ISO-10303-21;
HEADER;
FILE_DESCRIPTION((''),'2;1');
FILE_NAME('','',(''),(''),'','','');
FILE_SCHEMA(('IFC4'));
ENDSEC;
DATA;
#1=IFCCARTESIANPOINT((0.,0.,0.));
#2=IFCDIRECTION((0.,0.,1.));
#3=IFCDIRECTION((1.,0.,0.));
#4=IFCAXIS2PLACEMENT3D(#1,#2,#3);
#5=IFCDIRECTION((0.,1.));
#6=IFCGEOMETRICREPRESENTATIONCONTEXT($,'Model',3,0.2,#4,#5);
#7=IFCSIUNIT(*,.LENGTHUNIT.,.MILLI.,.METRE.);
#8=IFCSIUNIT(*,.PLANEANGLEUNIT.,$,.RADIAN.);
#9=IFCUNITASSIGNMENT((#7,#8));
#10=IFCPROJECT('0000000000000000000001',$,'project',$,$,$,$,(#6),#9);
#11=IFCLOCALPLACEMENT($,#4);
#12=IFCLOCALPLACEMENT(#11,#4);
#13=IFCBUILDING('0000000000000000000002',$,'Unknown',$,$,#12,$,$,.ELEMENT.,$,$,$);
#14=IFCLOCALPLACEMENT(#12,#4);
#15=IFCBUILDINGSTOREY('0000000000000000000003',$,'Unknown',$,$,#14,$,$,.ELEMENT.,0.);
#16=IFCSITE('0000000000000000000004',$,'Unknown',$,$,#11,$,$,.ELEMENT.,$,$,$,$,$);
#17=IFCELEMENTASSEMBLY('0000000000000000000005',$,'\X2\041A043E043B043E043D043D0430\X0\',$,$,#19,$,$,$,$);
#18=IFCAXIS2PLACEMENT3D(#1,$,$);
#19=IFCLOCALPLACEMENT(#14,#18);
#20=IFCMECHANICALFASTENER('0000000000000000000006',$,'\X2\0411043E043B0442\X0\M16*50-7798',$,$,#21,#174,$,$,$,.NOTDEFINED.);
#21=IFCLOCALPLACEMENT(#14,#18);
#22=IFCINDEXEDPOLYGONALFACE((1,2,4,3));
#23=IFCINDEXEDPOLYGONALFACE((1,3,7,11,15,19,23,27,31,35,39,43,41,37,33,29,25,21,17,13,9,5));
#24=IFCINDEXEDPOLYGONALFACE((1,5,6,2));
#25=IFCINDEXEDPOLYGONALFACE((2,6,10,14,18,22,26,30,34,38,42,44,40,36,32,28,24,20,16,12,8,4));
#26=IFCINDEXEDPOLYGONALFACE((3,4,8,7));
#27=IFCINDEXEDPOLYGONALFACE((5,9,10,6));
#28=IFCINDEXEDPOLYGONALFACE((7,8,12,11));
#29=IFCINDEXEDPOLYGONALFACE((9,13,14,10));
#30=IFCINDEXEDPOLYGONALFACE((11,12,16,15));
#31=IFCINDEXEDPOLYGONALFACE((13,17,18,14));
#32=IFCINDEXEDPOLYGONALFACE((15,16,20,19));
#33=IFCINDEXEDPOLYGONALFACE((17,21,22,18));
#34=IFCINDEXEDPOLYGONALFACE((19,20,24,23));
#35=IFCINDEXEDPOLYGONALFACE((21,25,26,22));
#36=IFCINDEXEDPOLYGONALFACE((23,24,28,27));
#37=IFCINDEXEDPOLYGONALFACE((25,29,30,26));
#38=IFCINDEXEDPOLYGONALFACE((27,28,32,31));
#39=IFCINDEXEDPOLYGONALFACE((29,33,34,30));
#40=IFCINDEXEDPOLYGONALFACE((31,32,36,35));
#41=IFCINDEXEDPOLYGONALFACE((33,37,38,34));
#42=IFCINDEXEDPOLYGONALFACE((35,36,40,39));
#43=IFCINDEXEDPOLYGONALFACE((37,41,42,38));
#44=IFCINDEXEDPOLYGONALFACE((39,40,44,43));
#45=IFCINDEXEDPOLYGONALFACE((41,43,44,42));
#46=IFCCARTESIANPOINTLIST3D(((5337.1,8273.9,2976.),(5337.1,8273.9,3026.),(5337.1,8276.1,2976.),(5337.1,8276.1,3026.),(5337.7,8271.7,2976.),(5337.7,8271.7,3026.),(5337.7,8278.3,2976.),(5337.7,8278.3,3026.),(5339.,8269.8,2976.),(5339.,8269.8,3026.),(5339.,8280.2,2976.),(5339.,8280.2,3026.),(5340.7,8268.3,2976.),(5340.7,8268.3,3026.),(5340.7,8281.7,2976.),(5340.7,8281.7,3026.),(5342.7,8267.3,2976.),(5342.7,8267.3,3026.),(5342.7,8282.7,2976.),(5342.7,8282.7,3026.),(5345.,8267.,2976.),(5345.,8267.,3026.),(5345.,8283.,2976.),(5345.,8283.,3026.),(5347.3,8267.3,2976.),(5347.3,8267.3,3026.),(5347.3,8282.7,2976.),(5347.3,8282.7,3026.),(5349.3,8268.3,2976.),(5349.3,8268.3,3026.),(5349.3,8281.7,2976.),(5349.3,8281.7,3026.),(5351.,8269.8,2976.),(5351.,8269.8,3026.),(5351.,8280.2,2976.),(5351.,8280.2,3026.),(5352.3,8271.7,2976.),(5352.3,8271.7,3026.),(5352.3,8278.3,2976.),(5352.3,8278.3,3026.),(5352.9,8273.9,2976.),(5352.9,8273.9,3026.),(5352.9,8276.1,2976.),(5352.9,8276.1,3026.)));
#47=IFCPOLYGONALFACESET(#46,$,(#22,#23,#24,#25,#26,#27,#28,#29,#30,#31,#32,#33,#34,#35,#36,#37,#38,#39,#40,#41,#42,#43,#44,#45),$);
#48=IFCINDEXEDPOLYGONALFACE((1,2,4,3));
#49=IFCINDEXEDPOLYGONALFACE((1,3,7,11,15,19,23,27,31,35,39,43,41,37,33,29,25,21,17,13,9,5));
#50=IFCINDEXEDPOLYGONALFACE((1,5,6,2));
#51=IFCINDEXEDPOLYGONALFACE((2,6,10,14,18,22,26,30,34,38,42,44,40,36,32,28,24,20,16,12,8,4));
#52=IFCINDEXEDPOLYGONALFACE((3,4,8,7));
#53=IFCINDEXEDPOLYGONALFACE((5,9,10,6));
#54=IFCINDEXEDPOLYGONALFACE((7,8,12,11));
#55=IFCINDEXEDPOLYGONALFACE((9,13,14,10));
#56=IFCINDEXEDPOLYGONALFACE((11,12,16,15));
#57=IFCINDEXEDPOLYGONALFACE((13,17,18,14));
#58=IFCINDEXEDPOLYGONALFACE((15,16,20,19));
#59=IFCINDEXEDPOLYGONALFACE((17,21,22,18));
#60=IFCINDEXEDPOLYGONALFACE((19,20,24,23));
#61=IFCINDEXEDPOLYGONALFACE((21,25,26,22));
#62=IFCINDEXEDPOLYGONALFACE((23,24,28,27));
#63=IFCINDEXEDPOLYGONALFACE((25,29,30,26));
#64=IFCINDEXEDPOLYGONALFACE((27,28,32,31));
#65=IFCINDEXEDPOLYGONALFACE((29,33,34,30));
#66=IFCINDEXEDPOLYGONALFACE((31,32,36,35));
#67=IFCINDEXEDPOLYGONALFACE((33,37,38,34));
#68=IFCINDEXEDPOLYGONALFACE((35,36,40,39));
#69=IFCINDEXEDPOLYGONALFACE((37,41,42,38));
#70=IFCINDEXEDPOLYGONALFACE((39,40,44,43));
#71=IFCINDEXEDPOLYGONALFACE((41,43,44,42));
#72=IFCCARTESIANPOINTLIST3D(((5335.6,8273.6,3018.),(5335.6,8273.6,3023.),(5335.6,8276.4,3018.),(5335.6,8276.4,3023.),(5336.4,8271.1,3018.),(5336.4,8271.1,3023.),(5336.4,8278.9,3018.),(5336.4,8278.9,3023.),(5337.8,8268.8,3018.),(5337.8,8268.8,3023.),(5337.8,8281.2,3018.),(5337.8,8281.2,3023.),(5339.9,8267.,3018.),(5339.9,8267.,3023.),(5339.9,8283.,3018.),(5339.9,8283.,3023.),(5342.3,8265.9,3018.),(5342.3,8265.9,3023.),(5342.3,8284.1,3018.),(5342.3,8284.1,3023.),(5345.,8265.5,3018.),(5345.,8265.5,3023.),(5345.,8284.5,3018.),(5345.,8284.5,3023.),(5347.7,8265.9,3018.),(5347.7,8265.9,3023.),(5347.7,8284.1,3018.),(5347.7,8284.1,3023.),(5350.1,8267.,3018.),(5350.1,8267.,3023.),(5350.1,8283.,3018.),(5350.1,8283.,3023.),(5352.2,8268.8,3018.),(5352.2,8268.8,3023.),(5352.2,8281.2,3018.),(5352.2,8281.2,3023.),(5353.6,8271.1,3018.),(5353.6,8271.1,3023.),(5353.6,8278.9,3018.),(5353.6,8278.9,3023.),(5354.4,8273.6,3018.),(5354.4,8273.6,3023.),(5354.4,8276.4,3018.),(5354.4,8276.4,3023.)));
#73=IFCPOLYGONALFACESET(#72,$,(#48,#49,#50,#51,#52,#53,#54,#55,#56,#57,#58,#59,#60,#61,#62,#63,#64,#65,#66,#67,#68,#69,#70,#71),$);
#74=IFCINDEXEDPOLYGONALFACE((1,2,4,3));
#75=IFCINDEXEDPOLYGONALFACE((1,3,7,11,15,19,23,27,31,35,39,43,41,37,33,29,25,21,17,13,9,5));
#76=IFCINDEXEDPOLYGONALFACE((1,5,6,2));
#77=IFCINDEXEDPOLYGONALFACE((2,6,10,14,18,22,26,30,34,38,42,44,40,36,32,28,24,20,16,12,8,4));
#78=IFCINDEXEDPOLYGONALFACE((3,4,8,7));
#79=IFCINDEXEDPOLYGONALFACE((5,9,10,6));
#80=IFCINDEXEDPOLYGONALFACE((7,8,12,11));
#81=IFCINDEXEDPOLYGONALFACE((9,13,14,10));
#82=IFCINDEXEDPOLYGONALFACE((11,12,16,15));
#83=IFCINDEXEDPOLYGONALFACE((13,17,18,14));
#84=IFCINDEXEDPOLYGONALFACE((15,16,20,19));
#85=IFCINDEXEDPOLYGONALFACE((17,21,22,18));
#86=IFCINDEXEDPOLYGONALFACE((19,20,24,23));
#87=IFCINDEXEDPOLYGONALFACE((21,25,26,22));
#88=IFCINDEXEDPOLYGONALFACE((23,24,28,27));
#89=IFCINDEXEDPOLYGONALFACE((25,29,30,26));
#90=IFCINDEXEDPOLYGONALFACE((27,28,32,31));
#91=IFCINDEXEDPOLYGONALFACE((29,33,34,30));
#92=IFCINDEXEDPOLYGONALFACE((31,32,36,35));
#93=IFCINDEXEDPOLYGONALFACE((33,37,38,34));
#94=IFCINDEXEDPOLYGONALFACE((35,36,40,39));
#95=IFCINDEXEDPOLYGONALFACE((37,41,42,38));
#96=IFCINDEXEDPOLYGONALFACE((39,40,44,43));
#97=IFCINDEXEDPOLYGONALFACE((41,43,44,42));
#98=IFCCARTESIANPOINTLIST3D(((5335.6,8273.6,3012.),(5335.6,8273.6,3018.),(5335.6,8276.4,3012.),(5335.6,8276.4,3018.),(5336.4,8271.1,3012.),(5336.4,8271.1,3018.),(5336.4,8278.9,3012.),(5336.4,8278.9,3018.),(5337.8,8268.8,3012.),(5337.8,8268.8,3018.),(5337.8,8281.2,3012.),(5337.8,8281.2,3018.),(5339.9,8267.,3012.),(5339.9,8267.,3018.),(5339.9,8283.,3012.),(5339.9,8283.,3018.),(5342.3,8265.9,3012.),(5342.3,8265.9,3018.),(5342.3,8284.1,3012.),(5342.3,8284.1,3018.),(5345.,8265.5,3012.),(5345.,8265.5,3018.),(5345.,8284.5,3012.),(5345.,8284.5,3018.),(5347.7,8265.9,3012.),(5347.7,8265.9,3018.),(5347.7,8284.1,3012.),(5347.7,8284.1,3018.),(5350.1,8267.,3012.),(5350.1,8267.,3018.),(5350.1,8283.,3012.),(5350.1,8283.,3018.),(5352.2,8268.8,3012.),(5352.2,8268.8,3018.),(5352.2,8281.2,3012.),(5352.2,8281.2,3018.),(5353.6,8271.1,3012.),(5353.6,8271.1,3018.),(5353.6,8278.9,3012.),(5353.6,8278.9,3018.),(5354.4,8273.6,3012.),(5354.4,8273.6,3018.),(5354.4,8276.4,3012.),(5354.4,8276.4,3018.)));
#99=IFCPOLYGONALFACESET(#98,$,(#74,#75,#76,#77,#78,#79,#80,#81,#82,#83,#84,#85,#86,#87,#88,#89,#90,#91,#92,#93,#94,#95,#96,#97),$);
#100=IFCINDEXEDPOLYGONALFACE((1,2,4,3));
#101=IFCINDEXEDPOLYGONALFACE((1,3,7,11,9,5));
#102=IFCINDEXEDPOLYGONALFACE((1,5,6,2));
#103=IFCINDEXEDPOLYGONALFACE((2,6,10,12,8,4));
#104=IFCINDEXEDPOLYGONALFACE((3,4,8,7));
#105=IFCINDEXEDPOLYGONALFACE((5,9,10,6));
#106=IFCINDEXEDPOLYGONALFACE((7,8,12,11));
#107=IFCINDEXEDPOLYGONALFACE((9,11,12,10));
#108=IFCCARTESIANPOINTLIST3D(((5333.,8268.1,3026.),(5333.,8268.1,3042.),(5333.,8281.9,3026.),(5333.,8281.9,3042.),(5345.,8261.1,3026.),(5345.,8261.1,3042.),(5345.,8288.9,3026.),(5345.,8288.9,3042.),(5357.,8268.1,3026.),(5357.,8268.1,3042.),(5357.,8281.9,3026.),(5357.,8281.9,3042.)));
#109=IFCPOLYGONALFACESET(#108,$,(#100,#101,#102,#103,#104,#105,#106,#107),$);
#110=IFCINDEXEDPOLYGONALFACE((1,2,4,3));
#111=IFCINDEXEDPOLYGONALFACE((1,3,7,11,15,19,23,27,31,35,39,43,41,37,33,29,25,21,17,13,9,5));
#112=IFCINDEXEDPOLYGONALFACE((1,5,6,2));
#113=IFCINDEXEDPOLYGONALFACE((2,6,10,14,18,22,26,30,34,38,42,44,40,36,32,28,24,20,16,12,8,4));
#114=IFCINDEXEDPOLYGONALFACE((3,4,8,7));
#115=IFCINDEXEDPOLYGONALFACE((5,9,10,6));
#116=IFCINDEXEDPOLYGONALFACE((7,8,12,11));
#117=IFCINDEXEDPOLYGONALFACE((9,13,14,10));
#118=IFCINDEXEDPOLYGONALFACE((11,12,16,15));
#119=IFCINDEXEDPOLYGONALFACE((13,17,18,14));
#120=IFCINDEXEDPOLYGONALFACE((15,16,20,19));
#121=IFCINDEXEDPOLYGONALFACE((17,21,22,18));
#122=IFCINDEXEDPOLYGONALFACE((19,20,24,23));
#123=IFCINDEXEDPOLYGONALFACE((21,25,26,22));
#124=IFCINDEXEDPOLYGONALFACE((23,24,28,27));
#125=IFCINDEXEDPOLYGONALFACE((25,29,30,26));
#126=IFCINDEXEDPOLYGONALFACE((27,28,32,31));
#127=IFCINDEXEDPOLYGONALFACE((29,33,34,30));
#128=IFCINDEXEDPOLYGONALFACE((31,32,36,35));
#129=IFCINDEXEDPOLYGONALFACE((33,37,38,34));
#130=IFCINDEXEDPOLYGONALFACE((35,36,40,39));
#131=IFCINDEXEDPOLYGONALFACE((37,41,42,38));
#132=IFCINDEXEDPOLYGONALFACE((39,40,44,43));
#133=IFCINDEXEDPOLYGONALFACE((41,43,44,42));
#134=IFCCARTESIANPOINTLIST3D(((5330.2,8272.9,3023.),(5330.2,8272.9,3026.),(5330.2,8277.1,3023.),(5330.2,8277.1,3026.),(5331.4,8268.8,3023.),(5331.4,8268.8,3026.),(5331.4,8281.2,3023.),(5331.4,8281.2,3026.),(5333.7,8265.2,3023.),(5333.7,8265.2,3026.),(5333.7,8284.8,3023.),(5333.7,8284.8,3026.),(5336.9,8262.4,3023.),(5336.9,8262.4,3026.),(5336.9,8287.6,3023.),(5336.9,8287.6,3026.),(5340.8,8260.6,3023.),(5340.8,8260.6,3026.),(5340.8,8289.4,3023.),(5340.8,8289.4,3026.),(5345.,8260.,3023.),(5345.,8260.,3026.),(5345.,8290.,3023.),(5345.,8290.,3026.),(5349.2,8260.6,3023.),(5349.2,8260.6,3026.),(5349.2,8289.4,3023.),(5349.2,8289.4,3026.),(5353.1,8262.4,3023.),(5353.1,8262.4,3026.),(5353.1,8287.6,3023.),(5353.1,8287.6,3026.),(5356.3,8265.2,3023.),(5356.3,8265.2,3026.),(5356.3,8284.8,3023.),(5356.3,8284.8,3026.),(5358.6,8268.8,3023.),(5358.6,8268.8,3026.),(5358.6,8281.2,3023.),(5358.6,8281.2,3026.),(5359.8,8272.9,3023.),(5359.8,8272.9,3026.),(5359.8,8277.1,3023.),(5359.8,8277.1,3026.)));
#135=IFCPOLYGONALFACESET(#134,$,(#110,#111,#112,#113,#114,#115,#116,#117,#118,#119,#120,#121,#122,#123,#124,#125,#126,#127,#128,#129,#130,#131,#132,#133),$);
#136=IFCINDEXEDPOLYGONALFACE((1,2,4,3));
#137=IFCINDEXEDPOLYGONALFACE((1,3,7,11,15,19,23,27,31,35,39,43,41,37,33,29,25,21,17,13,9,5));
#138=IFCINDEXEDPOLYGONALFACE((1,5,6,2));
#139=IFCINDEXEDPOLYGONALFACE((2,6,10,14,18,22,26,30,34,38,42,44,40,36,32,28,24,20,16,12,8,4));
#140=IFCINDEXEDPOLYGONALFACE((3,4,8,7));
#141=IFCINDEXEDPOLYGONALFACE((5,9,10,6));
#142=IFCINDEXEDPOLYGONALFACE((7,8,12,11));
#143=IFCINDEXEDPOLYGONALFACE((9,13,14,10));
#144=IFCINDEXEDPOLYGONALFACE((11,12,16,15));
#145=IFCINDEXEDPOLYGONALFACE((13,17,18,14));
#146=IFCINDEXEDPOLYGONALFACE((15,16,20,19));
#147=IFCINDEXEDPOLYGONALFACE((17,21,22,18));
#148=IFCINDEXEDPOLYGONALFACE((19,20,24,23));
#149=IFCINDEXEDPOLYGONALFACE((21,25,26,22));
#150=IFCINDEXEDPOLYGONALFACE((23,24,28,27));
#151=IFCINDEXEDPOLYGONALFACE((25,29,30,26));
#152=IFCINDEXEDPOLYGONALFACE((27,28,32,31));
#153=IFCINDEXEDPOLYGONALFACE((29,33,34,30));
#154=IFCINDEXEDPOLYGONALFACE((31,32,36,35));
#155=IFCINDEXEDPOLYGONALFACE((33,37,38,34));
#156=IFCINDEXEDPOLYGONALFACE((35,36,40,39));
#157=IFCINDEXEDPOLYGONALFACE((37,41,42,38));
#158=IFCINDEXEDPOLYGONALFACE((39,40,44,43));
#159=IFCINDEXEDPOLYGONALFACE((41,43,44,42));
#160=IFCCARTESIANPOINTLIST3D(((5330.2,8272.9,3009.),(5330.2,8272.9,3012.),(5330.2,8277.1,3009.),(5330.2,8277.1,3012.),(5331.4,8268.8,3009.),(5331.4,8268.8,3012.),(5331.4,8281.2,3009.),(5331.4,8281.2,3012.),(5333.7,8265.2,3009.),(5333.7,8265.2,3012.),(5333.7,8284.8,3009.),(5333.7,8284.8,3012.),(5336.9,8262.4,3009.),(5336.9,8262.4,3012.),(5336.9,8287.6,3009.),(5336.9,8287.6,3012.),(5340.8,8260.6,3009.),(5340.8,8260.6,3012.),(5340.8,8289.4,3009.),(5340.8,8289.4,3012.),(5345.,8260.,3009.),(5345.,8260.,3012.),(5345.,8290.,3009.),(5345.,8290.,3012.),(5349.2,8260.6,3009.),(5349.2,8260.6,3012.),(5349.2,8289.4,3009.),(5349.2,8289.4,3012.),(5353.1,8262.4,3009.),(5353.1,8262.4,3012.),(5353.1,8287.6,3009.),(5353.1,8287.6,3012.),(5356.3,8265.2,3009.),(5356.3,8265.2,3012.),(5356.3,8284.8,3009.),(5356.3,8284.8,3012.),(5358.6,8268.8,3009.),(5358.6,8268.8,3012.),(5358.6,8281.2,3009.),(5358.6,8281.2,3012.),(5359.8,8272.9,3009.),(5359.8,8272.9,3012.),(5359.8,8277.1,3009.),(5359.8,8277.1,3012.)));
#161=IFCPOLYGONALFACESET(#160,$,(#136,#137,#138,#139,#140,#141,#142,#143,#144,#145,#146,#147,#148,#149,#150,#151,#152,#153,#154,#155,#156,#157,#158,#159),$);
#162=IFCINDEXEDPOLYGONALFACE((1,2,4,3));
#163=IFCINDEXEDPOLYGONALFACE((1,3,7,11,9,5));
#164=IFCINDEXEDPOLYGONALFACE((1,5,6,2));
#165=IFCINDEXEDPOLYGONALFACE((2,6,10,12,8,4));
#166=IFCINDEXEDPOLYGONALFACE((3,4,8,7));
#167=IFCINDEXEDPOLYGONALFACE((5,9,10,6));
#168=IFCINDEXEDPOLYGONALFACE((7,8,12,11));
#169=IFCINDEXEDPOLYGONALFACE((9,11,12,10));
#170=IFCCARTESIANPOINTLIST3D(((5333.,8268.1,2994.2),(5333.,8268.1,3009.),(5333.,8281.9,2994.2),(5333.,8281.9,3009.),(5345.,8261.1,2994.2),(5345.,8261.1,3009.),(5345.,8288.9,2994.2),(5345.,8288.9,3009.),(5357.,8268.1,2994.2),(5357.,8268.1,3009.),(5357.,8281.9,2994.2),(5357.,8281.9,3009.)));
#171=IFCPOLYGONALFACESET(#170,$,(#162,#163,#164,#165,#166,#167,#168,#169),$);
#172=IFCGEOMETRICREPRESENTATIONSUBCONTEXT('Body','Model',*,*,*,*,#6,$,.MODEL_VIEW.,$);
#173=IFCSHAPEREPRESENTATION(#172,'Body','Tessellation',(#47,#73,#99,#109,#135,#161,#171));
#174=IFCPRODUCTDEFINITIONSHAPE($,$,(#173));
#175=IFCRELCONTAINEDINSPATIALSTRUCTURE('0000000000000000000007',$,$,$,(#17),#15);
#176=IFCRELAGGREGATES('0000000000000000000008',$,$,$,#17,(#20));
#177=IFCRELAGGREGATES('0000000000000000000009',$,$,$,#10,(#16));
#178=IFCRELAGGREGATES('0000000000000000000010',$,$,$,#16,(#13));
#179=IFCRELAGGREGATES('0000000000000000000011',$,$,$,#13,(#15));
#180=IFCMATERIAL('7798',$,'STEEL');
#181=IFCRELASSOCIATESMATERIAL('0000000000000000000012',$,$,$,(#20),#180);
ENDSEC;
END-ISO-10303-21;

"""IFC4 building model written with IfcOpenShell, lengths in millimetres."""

from ifc_helpers import new_model, si_unit, direction, frame, origin_with_axes, place, context, subcontext, project, spatial, line, arc, indexed_curve, outline, extrude, source, transform, mapped, material, element, aggregate, save


model = new_model("IFC4")

# Units and contexts
model_context = context("Model", 3, precision=0.2, world=origin_with_axes(), true_north=direction((0.0, 1.0)))
body_context = subcontext(model_context, "Body", "Model", "MODEL_VIEW")
ifc_project = project(units=[si_unit("LENGTHUNIT", "METRE", prefix="MILLI"), si_unit("PLANEANGLEUNIT", "RADIAN")], contexts=[model_context])

# Site, building, storey
site_placement = place(None, origin_with_axes())
site = spatial("IfcSite", under=ifc_project, at=site_placement, Name="Unknown", CompositionType="ELEMENT")
building_placement = place(site_placement, origin_with_axes())
building = spatial("IfcBuilding", under=site, at=building_placement, Name="Unknown", CompositionType="ELEMENT")
storey_placement = place(building_placement, origin_with_axes())
storey = spatial("IfcBuildingStorey", under=building, at=storey_placement, Name="Unknown", CompositionType="ELEMENT", Elevation=0.0)

# Element assembly
assembly_1_placement = place(storey_placement, frame((5400.0, 8400.0, -40.0), z_axis=(-1.0, 0.0, 0.0), x_axis=(0.0, 0.0, 1.0)))
assembly_1 = element("IfcElementAssembly", 1, at=assembly_1_placement, inside=storey, Name="Колонна")

# Mechanical fastener
ifc_material_1 = material(Name="7798", Category="STEEL")
shared_shape_1 = source(origin_with_axes(), body_context, "Body", "SweptSolid", [
    extrude(outline(indexed_curve([(8.0, 0.0), (0.0, 8.0), (-8.0, 0.0), (0.0, -8.0)], segments=[arc(1, 2, 3), arc(3, 4, 1)])), frame((0.0, 0.0, 8.0), z_axis=(0.0, 0.0, -1.0), x_axis=(0.0, 1.0, 0.0)), (0.0, 0.0, 1.0), 50.0),
    extrude(outline(indexed_curve([(9.5, 0.0), (0.0, 9.5), (-9.5, 0.0), (0.0, -9.5)], segments=[arc(1, 2, 3), arc(3, 4, 1)])), frame((0.0, 0.0, 5.0), z_axis=(0.0, 0.0, -1.0), x_axis=(0.0, 1.0, 0.0)), (0.0, 0.0, 1.0), 5.0),
    extrude(outline(indexed_curve([(9.5, 0.0), (0.0, 9.5), (-9.5, 0.0), (0.0, -9.5)], segments=[arc(1, 2, 3), arc(3, 4, 1)])), frame((0.0, 0.0, 0.0), z_axis=(0.0, 0.0, -1.0), x_axis=(0.0, 1.0, 0.0)), (0.0, 0.0, 1.0), 6.0),
    extrude(outline(indexed_curve([(13.9, 0.0), (6.9, 12.0), (-6.9, 12.0), (-13.9, 0.0), (-6.9, -12.0), (6.9, -12.0)], segments=[line(1, 2, 3, 4, 5, 6, 1)])), frame((0.0, 0.0, 24.0), z_axis=(0.0, 0.0, -1.0), x_axis=(0.0, 1.0, 0.0)), (0.0, 0.0, 1.0), 16.0),
    extrude(outline(indexed_curve([(15.0, 0.0), (0.0, 15.0), (-15.0, 0.0), (0.0, -15.0)], segments=[arc(1, 2, 3), arc(3, 4, 1)])), frame((0.0, 0.0, 8.0), z_axis=(0.0, 0.0, -1.0), x_axis=(0.0, 1.0, 0.0)), (0.0, 0.0, 1.0), 3.0),
    extrude(outline(indexed_curve([(15.0, 0.0), (0.0, 15.0), (-15.0, 0.0), (0.0, -15.0)], segments=[arc(1, 2, 3), arc(3, 4, 1)])), frame((0.0, 0.0, -6.0), z_axis=(0.0, 0.0, -1.0), x_axis=(0.0, 1.0, 0.0)), (0.0, 0.0, 1.0), 3.0),
    extrude(outline(indexed_curve([(13.9, 0.0), (6.9, 12.0), (-6.9, 12.0), (-13.9, 0.0), (-6.9, -12.0), (6.9, -12.0)], segments=[line(1, 2, 3, 4, 5, 6, 1)])), frame((0.0, 0.0, -9.0), z_axis=(0.0, 0.0, -1.0), x_axis=(0.0, 1.0, 0.0)), (0.0, 0.0, 1.0), 14.8),
])
mechanical_fastener_1_placement = place(assembly_1_placement, frame((3058.0, -125.0, 55.0), z_axis=(1.0, 0.0, 0.0), x_axis=(0.0, 0.0, -1.0)))
mechanical_fastener_1 = element("IfcMechanicalFastener", 2, at=mechanical_fastener_1_placement, material=ifc_material_1, Name="БолтM16*50-7798", PredefinedType="NOTDEFINED", context=body_context, shape_type="MappedRepresentation", body=[
    mapped(shared_shape_1, transform((0.0, 0.0, 0.0))),
])
aggregate(assembly_1, [mechanical_fastener_1])

save(model, "model.ifc")
